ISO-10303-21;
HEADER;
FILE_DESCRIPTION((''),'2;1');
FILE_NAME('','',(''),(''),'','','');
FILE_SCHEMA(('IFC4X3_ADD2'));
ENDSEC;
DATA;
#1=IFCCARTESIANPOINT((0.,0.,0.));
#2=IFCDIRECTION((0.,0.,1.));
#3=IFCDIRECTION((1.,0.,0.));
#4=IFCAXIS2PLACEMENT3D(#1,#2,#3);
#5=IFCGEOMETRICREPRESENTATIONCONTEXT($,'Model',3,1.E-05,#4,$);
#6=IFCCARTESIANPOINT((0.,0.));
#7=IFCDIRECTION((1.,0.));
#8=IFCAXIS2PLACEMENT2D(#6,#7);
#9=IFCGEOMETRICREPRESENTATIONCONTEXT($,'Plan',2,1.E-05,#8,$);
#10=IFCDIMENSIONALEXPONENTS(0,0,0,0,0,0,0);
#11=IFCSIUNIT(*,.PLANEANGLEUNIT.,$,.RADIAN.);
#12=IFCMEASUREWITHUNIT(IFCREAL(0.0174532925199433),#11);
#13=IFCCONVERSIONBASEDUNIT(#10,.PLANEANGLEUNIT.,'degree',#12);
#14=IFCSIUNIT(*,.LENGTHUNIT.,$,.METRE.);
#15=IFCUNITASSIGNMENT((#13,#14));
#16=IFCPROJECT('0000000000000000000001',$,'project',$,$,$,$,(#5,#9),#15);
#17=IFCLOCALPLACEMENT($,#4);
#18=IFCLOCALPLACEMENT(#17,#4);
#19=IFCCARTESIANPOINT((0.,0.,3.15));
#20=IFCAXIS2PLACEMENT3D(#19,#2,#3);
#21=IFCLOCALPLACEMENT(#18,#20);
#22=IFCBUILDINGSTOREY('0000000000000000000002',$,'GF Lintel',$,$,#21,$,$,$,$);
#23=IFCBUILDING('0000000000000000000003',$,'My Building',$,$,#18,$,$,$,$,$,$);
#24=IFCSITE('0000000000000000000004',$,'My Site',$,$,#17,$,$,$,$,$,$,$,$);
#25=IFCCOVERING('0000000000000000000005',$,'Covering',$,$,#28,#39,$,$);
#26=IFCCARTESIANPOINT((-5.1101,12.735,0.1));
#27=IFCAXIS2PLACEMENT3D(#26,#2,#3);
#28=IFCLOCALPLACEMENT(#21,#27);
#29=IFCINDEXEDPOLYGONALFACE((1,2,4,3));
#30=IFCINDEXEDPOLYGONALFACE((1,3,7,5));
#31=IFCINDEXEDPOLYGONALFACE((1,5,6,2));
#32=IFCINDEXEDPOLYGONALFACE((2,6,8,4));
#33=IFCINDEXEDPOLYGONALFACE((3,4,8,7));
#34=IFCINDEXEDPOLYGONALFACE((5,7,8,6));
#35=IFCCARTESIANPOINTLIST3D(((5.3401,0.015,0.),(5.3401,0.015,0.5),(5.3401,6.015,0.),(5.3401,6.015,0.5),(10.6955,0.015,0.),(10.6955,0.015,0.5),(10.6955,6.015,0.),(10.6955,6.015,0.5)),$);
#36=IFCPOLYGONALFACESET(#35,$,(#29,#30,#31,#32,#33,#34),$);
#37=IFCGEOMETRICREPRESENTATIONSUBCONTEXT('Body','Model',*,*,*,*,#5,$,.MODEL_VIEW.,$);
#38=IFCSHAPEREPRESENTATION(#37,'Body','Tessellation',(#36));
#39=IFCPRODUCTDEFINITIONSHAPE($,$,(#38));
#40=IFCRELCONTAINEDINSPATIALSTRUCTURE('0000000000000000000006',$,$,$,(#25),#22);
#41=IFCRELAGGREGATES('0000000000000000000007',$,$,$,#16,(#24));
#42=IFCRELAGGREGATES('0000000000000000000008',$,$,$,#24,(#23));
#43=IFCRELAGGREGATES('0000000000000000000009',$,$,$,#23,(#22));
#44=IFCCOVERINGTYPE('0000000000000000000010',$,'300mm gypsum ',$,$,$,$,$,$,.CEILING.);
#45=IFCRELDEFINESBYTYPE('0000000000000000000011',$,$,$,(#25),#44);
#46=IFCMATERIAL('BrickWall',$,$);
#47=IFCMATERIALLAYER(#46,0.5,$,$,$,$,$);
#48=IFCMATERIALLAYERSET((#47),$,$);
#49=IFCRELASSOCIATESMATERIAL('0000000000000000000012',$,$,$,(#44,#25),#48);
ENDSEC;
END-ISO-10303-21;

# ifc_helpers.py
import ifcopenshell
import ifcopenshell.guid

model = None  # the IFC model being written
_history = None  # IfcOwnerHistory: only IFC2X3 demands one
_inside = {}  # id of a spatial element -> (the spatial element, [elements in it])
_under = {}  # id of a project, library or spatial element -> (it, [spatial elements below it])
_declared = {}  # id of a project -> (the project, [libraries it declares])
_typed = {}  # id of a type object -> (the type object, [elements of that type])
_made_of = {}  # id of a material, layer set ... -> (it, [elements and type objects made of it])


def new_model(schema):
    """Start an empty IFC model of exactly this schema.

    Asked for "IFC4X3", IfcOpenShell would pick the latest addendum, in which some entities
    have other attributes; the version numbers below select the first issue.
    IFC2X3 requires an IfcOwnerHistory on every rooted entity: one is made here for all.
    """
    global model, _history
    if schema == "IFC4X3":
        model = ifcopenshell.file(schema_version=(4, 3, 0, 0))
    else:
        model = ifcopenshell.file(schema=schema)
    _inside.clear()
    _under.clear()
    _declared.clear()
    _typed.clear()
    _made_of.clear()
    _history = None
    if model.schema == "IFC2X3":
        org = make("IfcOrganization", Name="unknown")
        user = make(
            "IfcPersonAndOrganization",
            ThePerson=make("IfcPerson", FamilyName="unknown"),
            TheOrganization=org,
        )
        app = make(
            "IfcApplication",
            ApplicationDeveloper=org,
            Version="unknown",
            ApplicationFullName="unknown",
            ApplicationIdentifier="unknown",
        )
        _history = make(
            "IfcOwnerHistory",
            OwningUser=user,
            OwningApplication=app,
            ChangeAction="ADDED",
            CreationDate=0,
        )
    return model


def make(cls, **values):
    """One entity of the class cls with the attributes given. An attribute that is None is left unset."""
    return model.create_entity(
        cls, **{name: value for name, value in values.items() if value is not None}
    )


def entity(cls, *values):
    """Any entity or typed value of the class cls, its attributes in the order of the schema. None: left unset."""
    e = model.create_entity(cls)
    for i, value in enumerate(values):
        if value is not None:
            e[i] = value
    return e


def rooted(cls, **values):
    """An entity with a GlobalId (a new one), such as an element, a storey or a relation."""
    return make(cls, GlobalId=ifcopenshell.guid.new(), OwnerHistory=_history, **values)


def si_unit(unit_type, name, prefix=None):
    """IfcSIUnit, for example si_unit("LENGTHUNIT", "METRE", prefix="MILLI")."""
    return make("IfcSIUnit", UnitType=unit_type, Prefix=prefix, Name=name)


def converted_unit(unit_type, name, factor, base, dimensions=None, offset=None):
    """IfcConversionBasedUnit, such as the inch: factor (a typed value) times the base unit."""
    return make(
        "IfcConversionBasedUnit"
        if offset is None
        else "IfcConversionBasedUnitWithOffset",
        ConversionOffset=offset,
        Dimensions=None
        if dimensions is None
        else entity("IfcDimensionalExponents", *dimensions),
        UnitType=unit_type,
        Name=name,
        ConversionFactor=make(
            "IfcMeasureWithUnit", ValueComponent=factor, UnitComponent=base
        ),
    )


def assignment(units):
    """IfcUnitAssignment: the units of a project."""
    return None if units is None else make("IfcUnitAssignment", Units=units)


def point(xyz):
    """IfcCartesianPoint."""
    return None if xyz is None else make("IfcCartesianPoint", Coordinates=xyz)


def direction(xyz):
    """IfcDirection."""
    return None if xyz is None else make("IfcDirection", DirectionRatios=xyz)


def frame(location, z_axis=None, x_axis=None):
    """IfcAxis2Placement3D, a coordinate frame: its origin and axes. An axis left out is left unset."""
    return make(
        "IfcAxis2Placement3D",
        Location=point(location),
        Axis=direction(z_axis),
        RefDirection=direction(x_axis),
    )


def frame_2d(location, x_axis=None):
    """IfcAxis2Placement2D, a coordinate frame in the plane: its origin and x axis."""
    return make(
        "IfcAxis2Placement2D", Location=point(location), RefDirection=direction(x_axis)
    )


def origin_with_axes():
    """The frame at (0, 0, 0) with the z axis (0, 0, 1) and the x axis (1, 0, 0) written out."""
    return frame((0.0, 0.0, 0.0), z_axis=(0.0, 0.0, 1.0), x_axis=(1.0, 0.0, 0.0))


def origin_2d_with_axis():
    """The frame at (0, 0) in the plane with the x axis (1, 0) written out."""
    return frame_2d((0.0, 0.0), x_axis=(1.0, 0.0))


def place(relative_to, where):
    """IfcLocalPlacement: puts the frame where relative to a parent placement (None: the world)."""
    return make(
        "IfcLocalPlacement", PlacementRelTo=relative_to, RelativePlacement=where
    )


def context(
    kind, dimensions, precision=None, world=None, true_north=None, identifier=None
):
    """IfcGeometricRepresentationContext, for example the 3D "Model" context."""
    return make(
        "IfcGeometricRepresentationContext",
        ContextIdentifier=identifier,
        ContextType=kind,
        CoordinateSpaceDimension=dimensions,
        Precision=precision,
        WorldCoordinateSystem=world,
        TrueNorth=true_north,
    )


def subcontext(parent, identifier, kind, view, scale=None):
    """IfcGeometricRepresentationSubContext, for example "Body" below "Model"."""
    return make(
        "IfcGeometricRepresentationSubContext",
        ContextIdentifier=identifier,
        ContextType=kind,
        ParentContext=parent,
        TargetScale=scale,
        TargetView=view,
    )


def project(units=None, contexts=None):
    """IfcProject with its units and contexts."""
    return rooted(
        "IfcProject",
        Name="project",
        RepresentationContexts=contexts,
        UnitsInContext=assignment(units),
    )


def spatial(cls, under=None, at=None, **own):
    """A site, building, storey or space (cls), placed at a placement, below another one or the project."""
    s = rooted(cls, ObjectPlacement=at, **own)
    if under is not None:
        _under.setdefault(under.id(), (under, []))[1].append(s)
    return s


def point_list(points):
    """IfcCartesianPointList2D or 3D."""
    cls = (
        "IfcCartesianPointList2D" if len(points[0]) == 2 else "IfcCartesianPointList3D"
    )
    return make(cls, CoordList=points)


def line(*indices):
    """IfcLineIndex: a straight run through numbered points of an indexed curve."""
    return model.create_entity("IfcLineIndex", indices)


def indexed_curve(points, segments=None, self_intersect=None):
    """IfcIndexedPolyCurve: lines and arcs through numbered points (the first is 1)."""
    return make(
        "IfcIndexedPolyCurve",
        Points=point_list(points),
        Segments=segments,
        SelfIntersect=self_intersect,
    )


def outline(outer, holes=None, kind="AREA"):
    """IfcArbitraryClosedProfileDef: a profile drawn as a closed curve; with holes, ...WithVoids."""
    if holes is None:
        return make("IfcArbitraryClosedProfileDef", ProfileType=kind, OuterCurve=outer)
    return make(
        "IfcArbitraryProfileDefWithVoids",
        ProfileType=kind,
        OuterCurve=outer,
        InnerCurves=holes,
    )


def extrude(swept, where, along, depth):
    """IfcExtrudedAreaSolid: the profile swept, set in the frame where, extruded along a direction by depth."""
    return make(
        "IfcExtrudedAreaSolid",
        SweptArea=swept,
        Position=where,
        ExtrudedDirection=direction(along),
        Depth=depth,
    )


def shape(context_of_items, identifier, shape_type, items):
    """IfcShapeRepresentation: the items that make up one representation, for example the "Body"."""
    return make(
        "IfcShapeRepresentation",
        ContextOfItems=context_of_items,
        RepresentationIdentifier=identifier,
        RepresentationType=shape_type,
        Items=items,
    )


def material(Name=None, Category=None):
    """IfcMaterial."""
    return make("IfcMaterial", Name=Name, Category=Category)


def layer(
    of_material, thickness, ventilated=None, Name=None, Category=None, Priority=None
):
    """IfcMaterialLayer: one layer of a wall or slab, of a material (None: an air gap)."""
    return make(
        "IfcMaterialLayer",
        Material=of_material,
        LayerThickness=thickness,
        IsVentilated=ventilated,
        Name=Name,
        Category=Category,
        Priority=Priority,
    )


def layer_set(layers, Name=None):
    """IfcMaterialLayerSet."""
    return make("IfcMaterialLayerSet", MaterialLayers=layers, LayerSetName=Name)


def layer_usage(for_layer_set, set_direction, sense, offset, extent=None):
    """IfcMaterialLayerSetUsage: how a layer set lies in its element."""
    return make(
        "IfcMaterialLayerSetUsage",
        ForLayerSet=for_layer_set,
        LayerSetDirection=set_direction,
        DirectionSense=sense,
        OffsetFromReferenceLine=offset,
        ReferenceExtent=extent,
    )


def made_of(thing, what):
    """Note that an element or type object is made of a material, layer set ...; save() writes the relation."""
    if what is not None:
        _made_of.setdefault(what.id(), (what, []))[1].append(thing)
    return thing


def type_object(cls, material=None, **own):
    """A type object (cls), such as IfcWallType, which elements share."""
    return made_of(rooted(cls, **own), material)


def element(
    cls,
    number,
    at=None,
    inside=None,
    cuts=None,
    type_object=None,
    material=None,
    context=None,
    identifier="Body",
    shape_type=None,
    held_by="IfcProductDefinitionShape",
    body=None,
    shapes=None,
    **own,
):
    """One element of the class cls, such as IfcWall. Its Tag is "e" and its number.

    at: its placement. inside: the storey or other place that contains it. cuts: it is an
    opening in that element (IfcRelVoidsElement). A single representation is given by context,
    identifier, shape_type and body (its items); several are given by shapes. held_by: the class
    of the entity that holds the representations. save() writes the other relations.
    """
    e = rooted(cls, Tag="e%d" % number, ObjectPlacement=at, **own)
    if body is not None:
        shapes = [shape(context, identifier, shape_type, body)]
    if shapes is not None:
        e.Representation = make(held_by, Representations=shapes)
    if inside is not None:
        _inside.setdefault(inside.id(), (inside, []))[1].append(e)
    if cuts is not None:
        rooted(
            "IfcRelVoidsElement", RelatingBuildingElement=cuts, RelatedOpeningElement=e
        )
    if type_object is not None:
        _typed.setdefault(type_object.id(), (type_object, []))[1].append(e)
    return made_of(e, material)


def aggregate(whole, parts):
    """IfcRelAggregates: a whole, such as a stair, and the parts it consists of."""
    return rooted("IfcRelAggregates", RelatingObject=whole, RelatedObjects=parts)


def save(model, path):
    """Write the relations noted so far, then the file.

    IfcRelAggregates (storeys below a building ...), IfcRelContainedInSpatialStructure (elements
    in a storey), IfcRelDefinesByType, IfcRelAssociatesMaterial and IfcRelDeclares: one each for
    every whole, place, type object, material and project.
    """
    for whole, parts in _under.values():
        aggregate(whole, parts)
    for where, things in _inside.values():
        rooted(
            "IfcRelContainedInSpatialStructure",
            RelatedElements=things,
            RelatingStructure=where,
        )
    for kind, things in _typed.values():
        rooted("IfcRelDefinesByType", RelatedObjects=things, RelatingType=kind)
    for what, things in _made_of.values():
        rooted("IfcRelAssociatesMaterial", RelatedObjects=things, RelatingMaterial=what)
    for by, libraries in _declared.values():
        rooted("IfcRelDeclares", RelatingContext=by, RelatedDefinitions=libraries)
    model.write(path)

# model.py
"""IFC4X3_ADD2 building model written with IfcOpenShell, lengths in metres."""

from ifc_helpers import new_model, entity, si_unit, converted_unit, frame, origin_with_axes, origin_2d_with_axis, place, context, subcontext, project, spatial, line, indexed_curve, outline, extrude, material, layer, layer_set, layer_usage, type_object, element, save


model = new_model("IFC4X3_ADD2")

# Units and contexts
model_context = context("Model", 3, precision=1e-05, world=origin_with_axes())
plan_context = context("Plan", 2, precision=1e-05, world=origin_2d_with_axis())
body_context = subcontext(model_context, "Body", "Model", "MODEL_VIEW")
ifc_project = project(units=[converted_unit("PLANEANGLEUNIT", "degree", entity("IfcReal", 0.0174532925199433), si_unit("PLANEANGLEUNIT", "RADIAN"), dimensions=[0, 0, 0, 0, 0, 0, 0]), si_unit("LENGTHUNIT", "METRE")], contexts=[model_context, plan_context])

# Site, building, storey
site_placement = place(None, origin_with_axes())
site = spatial("IfcSite", under=ifc_project, at=site_placement, Name="My Site")
building_placement = place(site_placement, origin_with_axes())
building = spatial("IfcBuilding", under=site, at=building_placement, Name="My Building")
storey_placement = place(building_placement, frame((0.0, 0.0, 3.15), z_axis=(0.0, 0.0, 1.0), x_axis=(1.0, 0.0, 0.0)))
storey = spatial("IfcBuildingStorey", under=building, at=storey_placement, Name="GF Lintel")

# Shared definitions
ifc_material = material(Name="BrickWall")

# Covering
ifc_layer_1 = layer(ifc_material, 0.5)
ifc_layer_set_1 = layer_set([ifc_layer_1])
ifc_layer_usage_1 = layer_usage(ifc_layer_set_1, "AXIS3", "POSITIVE", 0.0)
covering_type_1 = type_object("IfcCoveringType", Name="300mm gypsum ", PredefinedType="CEILING", material=ifc_layer_set_1)
covering_1_placement = place(storey_placement, frame((-5.1101, 12.735, 0.1), z_axis=(0.0, 0.0, 1.0), x_axis=(1.0, 0.0, 0.0)))
element("IfcCovering", 1, at=covering_1_placement, inside=storey, type_object=covering_type_1, material=ifc_layer_usage_1, Name="Covering", context=body_context, shape_type="SweptSolid", body=[
    extrude(outline(indexed_curve([(10.6955, 0.015), (5.3401, 0.015), (5.3401, 6.015), (10.6955, 6.015)], segments=[line(4, 1), line(1, 2), line(2, 3), line(3, 4)], self_intersect=False)), None, (0.0, 0.0, 1.0), 0.5),
])

save(model, "model.ifc")
